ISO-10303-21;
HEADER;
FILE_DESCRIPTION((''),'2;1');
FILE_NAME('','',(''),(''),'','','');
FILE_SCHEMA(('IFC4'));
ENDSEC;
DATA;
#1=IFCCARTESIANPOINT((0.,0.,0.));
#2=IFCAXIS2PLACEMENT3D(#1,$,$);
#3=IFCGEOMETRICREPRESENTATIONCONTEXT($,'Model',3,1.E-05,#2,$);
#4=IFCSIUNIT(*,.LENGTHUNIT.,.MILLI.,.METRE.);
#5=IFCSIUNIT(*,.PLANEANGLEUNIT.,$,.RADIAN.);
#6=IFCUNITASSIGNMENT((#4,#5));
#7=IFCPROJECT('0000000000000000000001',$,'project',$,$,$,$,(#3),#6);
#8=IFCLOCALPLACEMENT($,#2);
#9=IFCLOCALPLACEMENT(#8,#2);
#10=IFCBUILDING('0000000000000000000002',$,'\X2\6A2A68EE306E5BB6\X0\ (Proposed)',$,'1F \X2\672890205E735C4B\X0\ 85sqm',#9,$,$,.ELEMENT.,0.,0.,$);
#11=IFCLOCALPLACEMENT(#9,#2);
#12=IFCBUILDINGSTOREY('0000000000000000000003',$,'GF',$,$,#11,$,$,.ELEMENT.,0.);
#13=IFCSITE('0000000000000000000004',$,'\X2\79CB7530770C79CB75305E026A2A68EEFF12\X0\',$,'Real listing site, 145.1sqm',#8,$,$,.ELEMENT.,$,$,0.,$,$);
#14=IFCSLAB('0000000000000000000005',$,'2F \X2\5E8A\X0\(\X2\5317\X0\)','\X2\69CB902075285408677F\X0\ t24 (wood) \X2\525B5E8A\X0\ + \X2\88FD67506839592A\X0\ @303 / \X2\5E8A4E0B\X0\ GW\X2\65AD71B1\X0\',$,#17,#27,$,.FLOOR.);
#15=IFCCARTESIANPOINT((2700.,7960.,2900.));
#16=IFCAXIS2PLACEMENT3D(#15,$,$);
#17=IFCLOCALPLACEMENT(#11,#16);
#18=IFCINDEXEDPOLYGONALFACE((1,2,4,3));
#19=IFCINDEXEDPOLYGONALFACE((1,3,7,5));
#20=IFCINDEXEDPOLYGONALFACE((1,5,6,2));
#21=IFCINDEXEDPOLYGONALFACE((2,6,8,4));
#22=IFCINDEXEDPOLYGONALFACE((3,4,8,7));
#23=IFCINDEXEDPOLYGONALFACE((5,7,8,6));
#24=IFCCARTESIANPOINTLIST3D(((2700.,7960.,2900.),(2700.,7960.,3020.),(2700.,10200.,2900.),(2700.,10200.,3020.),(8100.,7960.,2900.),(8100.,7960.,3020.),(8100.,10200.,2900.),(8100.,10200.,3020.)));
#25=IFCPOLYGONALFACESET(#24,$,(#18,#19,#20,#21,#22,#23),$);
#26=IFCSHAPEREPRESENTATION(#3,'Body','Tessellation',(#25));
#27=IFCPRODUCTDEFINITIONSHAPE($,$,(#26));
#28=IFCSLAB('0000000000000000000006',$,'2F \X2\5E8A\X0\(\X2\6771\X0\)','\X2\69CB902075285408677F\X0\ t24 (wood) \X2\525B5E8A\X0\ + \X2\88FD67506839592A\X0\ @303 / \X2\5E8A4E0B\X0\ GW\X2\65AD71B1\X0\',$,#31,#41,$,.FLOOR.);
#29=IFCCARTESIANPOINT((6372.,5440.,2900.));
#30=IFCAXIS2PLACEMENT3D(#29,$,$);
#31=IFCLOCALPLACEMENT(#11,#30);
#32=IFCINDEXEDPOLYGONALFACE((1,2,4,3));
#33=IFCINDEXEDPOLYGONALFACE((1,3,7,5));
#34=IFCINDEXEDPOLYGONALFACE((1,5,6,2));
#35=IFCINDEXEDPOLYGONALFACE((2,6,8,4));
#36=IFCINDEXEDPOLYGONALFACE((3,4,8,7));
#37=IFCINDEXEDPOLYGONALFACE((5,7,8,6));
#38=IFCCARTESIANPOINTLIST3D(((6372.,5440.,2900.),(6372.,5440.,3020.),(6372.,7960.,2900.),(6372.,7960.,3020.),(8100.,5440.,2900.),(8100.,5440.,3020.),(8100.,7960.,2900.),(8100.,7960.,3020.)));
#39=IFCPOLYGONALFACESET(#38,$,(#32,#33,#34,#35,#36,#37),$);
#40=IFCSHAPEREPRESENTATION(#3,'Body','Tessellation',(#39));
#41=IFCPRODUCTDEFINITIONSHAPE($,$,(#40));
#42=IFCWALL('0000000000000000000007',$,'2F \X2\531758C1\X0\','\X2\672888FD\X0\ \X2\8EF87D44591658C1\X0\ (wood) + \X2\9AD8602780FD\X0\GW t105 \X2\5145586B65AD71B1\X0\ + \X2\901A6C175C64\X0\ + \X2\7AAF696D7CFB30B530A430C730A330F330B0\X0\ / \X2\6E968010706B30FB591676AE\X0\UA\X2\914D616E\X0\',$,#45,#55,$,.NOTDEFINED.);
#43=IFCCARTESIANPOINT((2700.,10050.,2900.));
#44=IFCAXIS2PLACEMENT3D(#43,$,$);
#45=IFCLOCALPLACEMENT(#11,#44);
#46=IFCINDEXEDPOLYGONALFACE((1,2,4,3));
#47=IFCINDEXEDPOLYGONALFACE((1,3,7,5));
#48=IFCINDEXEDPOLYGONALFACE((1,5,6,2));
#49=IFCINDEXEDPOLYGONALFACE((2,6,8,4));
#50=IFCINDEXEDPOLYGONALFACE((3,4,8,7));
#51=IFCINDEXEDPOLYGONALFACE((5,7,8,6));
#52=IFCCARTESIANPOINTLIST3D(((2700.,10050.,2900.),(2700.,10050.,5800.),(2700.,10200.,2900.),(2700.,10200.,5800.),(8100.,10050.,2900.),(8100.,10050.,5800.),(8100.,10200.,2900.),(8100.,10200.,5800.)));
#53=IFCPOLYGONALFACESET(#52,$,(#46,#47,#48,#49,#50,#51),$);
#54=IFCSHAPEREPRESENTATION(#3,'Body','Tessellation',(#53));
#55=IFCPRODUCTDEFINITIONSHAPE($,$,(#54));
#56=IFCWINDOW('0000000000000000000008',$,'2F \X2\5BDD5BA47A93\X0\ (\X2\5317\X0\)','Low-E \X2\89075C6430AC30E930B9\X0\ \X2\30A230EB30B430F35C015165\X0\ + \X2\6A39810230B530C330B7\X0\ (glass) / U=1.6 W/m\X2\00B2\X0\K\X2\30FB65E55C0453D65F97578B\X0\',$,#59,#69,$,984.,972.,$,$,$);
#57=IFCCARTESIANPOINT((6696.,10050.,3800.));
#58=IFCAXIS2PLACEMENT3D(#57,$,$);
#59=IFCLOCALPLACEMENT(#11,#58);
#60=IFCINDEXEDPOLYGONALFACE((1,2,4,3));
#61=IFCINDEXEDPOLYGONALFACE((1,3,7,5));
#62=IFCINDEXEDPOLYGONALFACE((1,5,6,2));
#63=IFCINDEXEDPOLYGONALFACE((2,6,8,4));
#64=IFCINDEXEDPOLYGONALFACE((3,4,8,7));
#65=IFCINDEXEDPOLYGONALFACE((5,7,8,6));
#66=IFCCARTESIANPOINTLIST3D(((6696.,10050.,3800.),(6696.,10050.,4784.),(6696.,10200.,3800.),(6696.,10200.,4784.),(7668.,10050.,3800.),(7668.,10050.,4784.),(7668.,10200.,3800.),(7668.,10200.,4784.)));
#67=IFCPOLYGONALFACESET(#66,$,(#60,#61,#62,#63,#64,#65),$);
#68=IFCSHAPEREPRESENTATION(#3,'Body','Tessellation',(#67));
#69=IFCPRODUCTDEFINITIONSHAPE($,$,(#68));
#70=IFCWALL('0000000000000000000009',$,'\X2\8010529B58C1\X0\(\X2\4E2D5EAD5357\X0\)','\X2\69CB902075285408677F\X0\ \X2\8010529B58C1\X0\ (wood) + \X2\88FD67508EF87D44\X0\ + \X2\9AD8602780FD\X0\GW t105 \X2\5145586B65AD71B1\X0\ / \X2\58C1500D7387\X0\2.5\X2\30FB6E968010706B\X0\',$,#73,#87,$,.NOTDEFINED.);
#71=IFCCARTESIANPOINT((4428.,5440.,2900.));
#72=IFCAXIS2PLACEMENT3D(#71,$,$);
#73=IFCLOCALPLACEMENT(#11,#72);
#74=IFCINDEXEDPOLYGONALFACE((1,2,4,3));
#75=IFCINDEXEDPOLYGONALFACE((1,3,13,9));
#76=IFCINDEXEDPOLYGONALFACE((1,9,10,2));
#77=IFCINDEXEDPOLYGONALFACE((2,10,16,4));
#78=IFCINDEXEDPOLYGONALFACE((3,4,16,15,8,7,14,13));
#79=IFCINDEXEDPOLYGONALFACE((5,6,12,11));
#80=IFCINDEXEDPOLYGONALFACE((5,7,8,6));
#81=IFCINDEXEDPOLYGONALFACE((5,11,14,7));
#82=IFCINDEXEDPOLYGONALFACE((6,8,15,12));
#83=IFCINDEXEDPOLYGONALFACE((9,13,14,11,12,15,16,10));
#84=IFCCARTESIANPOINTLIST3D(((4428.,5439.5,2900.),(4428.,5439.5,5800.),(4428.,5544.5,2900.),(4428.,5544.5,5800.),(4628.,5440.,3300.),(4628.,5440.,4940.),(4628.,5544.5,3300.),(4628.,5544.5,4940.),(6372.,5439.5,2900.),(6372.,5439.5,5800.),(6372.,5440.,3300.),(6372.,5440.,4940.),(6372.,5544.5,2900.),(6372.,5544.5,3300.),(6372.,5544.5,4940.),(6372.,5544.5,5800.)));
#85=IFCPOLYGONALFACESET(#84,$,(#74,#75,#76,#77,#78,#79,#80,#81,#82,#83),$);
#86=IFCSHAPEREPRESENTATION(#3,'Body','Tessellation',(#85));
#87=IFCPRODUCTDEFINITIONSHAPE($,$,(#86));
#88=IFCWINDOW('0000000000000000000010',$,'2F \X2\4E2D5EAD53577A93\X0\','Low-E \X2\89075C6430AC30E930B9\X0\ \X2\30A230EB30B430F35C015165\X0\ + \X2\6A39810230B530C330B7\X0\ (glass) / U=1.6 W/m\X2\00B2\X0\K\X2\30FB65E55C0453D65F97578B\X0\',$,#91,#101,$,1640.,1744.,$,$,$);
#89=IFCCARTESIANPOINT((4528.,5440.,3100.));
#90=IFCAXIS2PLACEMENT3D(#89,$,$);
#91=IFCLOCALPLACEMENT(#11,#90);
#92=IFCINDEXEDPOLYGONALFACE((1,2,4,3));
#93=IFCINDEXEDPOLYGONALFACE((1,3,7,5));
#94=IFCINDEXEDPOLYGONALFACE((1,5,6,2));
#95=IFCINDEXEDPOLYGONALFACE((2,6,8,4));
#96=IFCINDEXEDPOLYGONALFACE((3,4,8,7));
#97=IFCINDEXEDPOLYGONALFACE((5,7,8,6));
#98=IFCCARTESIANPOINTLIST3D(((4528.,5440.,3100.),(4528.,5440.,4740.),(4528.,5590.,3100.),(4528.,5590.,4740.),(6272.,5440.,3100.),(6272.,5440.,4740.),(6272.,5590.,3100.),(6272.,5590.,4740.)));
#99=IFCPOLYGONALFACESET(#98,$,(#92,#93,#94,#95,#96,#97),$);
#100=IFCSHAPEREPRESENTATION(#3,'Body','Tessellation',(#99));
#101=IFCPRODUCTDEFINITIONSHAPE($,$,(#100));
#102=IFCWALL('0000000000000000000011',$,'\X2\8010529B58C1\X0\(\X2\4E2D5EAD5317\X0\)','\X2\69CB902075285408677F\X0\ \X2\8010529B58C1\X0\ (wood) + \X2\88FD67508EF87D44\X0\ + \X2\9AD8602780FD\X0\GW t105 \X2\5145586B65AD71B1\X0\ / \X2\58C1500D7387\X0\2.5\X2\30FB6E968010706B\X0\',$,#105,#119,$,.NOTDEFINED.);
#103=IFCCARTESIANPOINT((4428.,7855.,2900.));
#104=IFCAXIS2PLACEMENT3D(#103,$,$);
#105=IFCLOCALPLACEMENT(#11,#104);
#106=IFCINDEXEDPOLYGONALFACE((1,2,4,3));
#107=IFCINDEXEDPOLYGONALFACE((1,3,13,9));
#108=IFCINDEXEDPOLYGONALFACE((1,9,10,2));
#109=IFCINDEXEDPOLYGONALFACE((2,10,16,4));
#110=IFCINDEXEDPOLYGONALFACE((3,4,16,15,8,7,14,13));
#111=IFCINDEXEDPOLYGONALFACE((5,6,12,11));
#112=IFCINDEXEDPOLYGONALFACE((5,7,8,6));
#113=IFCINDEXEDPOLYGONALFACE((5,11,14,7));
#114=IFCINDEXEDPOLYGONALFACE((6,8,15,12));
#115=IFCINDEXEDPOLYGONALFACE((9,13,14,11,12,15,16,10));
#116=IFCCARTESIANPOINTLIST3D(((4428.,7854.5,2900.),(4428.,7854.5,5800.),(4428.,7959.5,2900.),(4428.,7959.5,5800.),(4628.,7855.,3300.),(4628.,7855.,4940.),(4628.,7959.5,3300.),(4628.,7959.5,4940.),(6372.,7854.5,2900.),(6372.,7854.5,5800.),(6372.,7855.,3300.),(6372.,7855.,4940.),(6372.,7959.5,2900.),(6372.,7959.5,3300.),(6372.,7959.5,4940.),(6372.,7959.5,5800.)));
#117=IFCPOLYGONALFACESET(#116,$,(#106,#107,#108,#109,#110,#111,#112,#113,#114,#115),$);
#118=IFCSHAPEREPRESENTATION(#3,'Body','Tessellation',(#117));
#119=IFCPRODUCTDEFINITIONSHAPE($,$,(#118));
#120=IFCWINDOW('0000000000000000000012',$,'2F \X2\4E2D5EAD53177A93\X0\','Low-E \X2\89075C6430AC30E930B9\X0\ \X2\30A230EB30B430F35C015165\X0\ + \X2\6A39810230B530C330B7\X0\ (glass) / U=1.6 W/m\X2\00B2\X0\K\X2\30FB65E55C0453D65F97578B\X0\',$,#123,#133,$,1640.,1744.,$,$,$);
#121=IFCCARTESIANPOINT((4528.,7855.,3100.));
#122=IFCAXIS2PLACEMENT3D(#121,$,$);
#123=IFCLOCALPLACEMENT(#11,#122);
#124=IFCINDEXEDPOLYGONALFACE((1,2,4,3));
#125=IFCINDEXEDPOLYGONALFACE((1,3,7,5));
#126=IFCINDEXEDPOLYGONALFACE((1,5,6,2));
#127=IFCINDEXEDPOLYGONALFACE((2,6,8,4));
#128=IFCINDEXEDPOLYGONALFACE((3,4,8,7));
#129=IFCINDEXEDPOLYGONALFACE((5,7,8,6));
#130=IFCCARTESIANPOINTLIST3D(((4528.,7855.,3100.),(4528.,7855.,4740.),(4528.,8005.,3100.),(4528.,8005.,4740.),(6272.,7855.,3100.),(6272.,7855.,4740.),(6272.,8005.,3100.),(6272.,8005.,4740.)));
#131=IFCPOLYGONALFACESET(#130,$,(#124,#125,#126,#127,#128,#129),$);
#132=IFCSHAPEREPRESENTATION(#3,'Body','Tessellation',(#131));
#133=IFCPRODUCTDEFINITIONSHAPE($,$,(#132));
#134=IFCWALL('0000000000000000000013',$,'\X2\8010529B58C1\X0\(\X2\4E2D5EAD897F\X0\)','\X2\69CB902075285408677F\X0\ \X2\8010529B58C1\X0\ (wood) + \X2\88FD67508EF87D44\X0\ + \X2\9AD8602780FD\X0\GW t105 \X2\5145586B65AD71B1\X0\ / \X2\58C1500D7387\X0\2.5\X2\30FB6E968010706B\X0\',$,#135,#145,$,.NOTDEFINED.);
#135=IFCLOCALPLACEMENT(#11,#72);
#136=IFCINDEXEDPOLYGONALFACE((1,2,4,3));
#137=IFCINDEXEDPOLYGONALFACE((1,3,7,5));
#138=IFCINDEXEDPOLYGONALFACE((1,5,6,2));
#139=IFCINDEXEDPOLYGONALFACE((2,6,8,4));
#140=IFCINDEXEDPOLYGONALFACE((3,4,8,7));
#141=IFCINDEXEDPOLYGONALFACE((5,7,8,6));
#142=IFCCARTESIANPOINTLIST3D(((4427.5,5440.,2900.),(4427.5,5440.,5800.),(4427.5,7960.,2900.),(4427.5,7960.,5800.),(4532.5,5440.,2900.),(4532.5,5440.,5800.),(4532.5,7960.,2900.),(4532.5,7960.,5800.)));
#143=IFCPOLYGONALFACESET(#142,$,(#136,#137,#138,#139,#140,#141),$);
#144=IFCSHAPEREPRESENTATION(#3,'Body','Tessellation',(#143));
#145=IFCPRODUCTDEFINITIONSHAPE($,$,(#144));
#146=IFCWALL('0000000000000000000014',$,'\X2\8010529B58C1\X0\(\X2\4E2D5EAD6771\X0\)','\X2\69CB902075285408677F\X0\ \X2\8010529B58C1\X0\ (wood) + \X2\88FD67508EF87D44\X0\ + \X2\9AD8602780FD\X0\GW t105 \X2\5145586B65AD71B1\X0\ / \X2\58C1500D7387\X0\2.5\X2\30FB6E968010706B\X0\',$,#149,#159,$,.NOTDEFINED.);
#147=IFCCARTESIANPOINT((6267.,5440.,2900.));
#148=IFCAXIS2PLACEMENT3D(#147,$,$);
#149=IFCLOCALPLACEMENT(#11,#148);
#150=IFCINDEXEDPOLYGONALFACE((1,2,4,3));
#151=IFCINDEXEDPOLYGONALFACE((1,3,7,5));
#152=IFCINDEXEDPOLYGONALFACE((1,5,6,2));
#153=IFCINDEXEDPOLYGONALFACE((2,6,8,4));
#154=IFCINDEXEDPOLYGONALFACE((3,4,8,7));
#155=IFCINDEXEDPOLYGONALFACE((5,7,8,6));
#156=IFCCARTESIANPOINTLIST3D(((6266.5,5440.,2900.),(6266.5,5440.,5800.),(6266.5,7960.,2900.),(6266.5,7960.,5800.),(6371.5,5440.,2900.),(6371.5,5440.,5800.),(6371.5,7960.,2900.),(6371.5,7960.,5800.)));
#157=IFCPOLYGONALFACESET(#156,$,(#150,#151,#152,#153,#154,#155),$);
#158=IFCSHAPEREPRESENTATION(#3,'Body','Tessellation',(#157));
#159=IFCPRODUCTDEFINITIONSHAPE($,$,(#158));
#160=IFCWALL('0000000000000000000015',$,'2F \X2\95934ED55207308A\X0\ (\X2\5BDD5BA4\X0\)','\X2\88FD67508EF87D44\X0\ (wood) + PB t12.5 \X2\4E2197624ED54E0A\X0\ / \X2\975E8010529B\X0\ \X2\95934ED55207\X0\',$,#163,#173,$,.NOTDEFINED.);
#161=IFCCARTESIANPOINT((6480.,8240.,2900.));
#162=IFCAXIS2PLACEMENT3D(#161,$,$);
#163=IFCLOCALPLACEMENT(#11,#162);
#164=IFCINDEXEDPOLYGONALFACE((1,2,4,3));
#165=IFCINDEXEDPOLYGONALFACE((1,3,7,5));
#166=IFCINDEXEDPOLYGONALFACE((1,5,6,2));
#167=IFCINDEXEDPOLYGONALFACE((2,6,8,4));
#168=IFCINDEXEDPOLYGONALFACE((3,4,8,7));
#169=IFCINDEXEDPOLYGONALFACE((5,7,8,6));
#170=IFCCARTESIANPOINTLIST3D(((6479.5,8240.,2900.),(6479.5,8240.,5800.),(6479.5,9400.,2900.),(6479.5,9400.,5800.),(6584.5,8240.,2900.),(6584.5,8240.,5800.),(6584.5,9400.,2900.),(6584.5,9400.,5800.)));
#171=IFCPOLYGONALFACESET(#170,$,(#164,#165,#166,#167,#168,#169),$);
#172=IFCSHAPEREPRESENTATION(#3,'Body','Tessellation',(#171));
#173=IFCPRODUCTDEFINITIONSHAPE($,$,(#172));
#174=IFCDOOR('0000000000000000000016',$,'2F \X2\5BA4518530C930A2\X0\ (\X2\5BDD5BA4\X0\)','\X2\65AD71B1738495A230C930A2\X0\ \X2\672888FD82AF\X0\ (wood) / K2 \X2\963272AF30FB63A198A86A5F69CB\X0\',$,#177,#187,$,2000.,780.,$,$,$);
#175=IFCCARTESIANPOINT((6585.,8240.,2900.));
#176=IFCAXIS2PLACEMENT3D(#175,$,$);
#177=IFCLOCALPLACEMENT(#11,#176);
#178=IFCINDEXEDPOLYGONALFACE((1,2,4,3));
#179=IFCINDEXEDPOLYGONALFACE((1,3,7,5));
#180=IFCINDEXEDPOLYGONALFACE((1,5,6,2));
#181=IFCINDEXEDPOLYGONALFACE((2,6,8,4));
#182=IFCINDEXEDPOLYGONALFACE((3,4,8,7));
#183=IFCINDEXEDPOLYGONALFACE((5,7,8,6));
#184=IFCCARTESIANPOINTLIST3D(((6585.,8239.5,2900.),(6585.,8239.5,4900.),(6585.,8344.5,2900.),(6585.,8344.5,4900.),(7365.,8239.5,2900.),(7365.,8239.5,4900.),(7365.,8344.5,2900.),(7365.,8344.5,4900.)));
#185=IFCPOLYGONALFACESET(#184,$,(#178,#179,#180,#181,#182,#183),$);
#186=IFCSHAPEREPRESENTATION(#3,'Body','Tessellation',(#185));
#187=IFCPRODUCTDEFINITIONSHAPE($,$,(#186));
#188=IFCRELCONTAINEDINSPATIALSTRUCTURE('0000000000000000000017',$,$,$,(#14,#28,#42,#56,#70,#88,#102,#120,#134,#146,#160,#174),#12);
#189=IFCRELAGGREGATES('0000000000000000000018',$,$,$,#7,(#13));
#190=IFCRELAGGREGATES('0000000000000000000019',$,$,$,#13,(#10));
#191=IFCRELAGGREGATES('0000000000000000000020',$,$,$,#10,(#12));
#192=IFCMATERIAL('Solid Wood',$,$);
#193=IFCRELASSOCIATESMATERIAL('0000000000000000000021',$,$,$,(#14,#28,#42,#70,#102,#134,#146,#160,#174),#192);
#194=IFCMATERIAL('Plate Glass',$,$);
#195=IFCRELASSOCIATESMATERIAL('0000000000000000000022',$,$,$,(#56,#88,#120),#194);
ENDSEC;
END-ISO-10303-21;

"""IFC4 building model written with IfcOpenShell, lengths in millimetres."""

from ifc_helpers import new_model, si_unit, frame, frame_2d, origin, place, context, project, spatial, rectangle, extrude, material, element, fill, save


model = new_model("IFC4")

# Units and contexts
model_context = context("Model", 3, precision=1e-05, world=origin())
ifc_project = project(units=[si_unit("LENGTHUNIT", "METRE", prefix="MILLI"), si_unit("PLANEANGLEUNIT", "RADIAN")], contexts=[model_context])

# Site, building, storey
site_placement = place(None, origin())
site = spatial("IfcSite", under=ifc_project, at=site_placement, Name="秋田県秋田市横森２", ObjectType="Real listing site, 145.1sqm", CompositionType="ELEMENT", RefElevation=0.0)
building_placement = place(site_placement, origin())
building = spatial("IfcBuilding", under=site, at=building_placement, Name="横森の家 (Proposed)", ObjectType="1F 木造平屋 85sqm", CompositionType="ELEMENT", ElevationOfRefHeight=0.0, ElevationOfTerrain=0.0)
storey_placement = place(building_placement, origin())
storey = spatial("IfcBuildingStorey", under=building, at=storey_placement, Name="GF", CompositionType="ELEMENT", Elevation=0.0)

# Slabs
ifc_material_1 = material(Name="Solid Wood")
slab_1_placement = place(storey_placement, frame((2700.0, 7960.0, 2900.0)))
element("IfcSlab", 1, at=slab_1_placement, inside=storey, material=ifc_material_1, Name="2F 床(北)", Description="構造用合板 t24 (wood) 剛床 + 製材根太 @303 / 床下 GW断熱", PredefinedType="FLOOR", context=model_context, shape_type="SweptSolid", body=[
    extrude(rectangle(XDim=5400.0, YDim=2240.0, at=frame_2d((2700.0, 1120.0))), frame((2700.0, 7960.0, 2900.0)), (0.0, 0.0, 1.0), 120.0),
])
slab_2_placement = place(storey_placement, frame((6372.0, 5440.0, 2900.0)))
element("IfcSlab", 2, at=slab_2_placement, inside=storey, material=ifc_material_1, Name="2F 床(東)", Description="構造用合板 t24 (wood) 剛床 + 製材根太 @303 / 床下 GW断熱", PredefinedType="FLOOR", context=model_context, shape_type="SweptSolid", body=[
    extrude(rectangle(XDim=1728.0, YDim=2520.0, at=frame_2d((864.0, 1260.0))), frame((6372.0, 5440.0, 2900.0)), (0.0, 0.0, 1.0), 120.0),
])

# Walls, openings, windows
wall_1_placement = place(storey_placement, frame((2700.0, 10050.0, 2900.0)))
wall_1 = element("IfcWall", 3, at=wall_1_placement, inside=storey, material=ifc_material_1, Name="2F 北壁", Description="木製 軸組外壁 (wood) + 高性能GW t105 充填断熱 + 通気層 + 窯業系サイディング / 準耐火・外皮UA配慮", PredefinedType="NOTDEFINED", context=model_context, shape_type="SweptSolid", body=[
    extrude(rectangle(XDim=5400.0, YDim=150.0, at=frame_2d((2700.0, 75.0))), frame((2700.0, 10050.0, 2900.0)), (0.0, 0.0, 1.0), 2900.0),
])
opening_1_placement = place(storey_placement, frame((6696.0, 10050.0, 3800.0)))
opening_1 = element("IfcOpeningElement", 4, at=opening_1_placement, cuts=wall_1, PredefinedType="NOTDEFINED", context=model_context, shape_type="SweptSolid", body=[
    extrude(rectangle(XDim=972.0, YDim=150.0, at=frame_2d((486.0, 75.0))), frame((6696.0, 10050.0, 3800.0)), (0.0, 0.0, 1.0), 984.0),
])
ifc_material_2 = material(Name="Plate Glass")
window_1_placement = place(storey_placement, frame((6696.0, 10050.0, 3800.0)))
window_1 = element("IfcWindow", 5, at=window_1_placement, inside=storey, material=ifc_material_2, Name="2F 寝室窓 (北)", Description="Low-E 複層ガラス アルゴン封入 + 樹脂サッシ (glass) / U=1.6 W/m²K・日射取得型", OverallHeight=984.0, OverallWidth=972.0, context=model_context, shape_type="SweptSolid", body=[
    extrude(rectangle(XDim=972.0, YDim=150.0, at=frame_2d((486.0, 75.0))), frame((6696.0, 10050.0, 3800.0)), (0.0, 0.0, 1.0), 984.0),
])
fill(opening_1, window_1)
wall_2_placement = place(storey_placement, frame((4428.0, 5440.0, 2900.0)))
wall_2 = element("IfcWall", 6, at=wall_2_placement, inside=storey, material=ifc_material_1, Name="耐力壁(中庭南)", Description="構造用合板 耐力壁 (wood) + 製材軸組 + 高性能GW t105 充填断熱 / 壁倍率2.5・準耐火", PredefinedType="NOTDEFINED", context=model_context, shape_type="SweptSolid", body=[
    extrude(rectangle(XDim=1944.0, YDim=105.0, at=frame_2d((972.0, 52.0))), frame((4428.0, 5440.0, 2900.0)), (0.0, 0.0, 1.0), 2900.0),
])
opening_2_placement = place(storey_placement, frame((4528.0, 5440.0, 3100.0)))
opening_2 = element("IfcOpeningElement", 7, at=opening_2_placement, cuts=wall_2, PredefinedType="NOTDEFINED", context=model_context, shape_type="SweptSolid", body=[
    extrude(rectangle(XDim=1744.0, YDim=150.0, at=frame_2d((872.0, 75.0))), frame((4528.0, 5440.0, 3100.0)), (0.0, 0.0, 1.0), 1640.0),
])
window_2_placement = place(storey_placement, frame((4528.0, 5440.0, 3100.0)))
window_2 = element("IfcWindow", 8, at=window_2_placement, inside=storey, material=ifc_material_2, Name="2F 中庭南窓", Description="Low-E 複層ガラス アルゴン封入 + 樹脂サッシ (glass) / U=1.6 W/m²K・日射取得型", OverallHeight=1640.0, OverallWidth=1744.0, context=model_context, shape_type="SweptSolid", body=[
    extrude(rectangle(XDim=1744.0, YDim=150.0, at=frame_2d((872.0, 75.0))), frame((4528.0, 5440.0, 3100.0)), (0.0, 0.0, 1.0), 1640.0),
])
fill(opening_2, window_2)
wall_3_placement = place(storey_placement, frame((4428.0, 7855.0, 2900.0)))
wall_3 = element("IfcWall", 9, at=wall_3_placement, inside=storey, material=ifc_material_1, Name="耐力壁(中庭北)", Description="構造用合板 耐力壁 (wood) + 製材軸組 + 高性能GW t105 充填断熱 / 壁倍率2.5・準耐火", PredefinedType="NOTDEFINED", context=model_context, shape_type="SweptSolid", body=[
    extrude(rectangle(XDim=1944.0, YDim=105.0, at=frame_2d((972.0, 52.0))), frame((4428.0, 7855.0, 2900.0)), (0.0, 0.0, 1.0), 2900.0),
])
opening_3_placement = place(storey_placement, frame((4528.0, 7855.0, 3100.0)))
opening_3 = element("IfcOpeningElement", 10, at=opening_3_placement, cuts=wall_3, PredefinedType="NOTDEFINED", context=model_context, shape_type="SweptSolid", body=[
    extrude(rectangle(XDim=1744.0, YDim=150.0, at=frame_2d((872.0, 75.0))), frame((4528.0, 7855.0, 3100.0)), (0.0, 0.0, 1.0), 1640.0),
])
window_3_placement = place(storey_placement, frame((4528.0, 7855.0, 3100.0)))
window_3 = element("IfcWindow", 11, at=window_3_placement, inside=storey, material=ifc_material_2, Name="2F 中庭北窓", Description="Low-E 複層ガラス アルゴン封入 + 樹脂サッシ (glass) / U=1.6 W/m²K・日射取得型", OverallHeight=1640.0, OverallWidth=1744.0, context=model_context, shape_type="SweptSolid", body=[
    extrude(rectangle(XDim=1744.0, YDim=150.0, at=frame_2d((872.0, 75.0))), frame((4528.0, 7855.0, 3100.0)), (0.0, 0.0, 1.0), 1640.0),
])
fill(opening_3, window_3)

# Walls
wall_4_placement = place(storey_placement, frame((4428.0, 5440.0, 2900.0)))
element("IfcWall", 12, at=wall_4_placement, inside=storey, material=ifc_material_1, Name="耐力壁(中庭西)", Description="構造用合板 耐力壁 (wood) + 製材軸組 + 高性能GW t105 充填断熱 / 壁倍率2.5・準耐火", PredefinedType="NOTDEFINED", context=model_context, shape_type="SweptSolid", body=[
    extrude(rectangle(XDim=105.0, YDim=2520.0, at=frame_2d((52.0, 1260.0))), frame((4428.0, 5440.0, 2900.0)), (0.0, 0.0, 1.0), 2900.0),
])
wall_5_placement = place(storey_placement, frame((6267.0, 5440.0, 2900.0)))
element("IfcWall", 13, at=wall_5_placement, inside=storey, material=ifc_material_1, Name="耐力壁(中庭東)", Description="構造用合板 耐力壁 (wood) + 製材軸組 + 高性能GW t105 充填断熱 / 壁倍率2.5・準耐火", PredefinedType="NOTDEFINED", context=model_context, shape_type="SweptSolid", body=[
    extrude(rectangle(XDim=105.0, YDim=2520.0, at=frame_2d((52.0, 1260.0))), frame((6267.0, 5440.0, 2900.0)), (0.0, 0.0, 1.0), 2900.0),
])
wall_6_placement = place(storey_placement, frame((6480.0, 8240.0, 2900.0)))
element("IfcWall", 14, at=wall_6_placement, inside=storey, material=ifc_material_1, Name="2F 間仕切り (寝室)", Description="製材軸組 (wood) + PB t12.5 両面仕上 / 非耐力 間仕切", PredefinedType="NOTDEFINED", context=model_context, shape_type="SweptSolid", body=[
    extrude(rectangle(XDim=105.0, YDim=1160.0, at=frame_2d((52.0, 580.0))), frame((6480.0, 8240.0, 2900.0)), (0.0, 0.0, 1.0), 2900.0),
])

# Door
door_placement = place(storey_placement, frame((6585.0, 8240.0, 2900.0)))
element("IfcDoor", 15, at=door_placement, inside=storey, material=ifc_material_1, Name="2F 室内ドア (寝室)", Description="断熱玄関ドア 木製芯 (wood) / K2 防犯・採風機構", OverallHeight=2000.0, OverallWidth=780.0, context=model_context, shape_type="SweptSolid", body=[
    extrude(rectangle(XDim=780.0, YDim=105.0, at=frame_2d((390.0, 52.0))), frame((6585.0, 8240.0, 2900.0)), (0.0, 0.0, 1.0), 2000.0),
])

save(model, "model.ifc")
